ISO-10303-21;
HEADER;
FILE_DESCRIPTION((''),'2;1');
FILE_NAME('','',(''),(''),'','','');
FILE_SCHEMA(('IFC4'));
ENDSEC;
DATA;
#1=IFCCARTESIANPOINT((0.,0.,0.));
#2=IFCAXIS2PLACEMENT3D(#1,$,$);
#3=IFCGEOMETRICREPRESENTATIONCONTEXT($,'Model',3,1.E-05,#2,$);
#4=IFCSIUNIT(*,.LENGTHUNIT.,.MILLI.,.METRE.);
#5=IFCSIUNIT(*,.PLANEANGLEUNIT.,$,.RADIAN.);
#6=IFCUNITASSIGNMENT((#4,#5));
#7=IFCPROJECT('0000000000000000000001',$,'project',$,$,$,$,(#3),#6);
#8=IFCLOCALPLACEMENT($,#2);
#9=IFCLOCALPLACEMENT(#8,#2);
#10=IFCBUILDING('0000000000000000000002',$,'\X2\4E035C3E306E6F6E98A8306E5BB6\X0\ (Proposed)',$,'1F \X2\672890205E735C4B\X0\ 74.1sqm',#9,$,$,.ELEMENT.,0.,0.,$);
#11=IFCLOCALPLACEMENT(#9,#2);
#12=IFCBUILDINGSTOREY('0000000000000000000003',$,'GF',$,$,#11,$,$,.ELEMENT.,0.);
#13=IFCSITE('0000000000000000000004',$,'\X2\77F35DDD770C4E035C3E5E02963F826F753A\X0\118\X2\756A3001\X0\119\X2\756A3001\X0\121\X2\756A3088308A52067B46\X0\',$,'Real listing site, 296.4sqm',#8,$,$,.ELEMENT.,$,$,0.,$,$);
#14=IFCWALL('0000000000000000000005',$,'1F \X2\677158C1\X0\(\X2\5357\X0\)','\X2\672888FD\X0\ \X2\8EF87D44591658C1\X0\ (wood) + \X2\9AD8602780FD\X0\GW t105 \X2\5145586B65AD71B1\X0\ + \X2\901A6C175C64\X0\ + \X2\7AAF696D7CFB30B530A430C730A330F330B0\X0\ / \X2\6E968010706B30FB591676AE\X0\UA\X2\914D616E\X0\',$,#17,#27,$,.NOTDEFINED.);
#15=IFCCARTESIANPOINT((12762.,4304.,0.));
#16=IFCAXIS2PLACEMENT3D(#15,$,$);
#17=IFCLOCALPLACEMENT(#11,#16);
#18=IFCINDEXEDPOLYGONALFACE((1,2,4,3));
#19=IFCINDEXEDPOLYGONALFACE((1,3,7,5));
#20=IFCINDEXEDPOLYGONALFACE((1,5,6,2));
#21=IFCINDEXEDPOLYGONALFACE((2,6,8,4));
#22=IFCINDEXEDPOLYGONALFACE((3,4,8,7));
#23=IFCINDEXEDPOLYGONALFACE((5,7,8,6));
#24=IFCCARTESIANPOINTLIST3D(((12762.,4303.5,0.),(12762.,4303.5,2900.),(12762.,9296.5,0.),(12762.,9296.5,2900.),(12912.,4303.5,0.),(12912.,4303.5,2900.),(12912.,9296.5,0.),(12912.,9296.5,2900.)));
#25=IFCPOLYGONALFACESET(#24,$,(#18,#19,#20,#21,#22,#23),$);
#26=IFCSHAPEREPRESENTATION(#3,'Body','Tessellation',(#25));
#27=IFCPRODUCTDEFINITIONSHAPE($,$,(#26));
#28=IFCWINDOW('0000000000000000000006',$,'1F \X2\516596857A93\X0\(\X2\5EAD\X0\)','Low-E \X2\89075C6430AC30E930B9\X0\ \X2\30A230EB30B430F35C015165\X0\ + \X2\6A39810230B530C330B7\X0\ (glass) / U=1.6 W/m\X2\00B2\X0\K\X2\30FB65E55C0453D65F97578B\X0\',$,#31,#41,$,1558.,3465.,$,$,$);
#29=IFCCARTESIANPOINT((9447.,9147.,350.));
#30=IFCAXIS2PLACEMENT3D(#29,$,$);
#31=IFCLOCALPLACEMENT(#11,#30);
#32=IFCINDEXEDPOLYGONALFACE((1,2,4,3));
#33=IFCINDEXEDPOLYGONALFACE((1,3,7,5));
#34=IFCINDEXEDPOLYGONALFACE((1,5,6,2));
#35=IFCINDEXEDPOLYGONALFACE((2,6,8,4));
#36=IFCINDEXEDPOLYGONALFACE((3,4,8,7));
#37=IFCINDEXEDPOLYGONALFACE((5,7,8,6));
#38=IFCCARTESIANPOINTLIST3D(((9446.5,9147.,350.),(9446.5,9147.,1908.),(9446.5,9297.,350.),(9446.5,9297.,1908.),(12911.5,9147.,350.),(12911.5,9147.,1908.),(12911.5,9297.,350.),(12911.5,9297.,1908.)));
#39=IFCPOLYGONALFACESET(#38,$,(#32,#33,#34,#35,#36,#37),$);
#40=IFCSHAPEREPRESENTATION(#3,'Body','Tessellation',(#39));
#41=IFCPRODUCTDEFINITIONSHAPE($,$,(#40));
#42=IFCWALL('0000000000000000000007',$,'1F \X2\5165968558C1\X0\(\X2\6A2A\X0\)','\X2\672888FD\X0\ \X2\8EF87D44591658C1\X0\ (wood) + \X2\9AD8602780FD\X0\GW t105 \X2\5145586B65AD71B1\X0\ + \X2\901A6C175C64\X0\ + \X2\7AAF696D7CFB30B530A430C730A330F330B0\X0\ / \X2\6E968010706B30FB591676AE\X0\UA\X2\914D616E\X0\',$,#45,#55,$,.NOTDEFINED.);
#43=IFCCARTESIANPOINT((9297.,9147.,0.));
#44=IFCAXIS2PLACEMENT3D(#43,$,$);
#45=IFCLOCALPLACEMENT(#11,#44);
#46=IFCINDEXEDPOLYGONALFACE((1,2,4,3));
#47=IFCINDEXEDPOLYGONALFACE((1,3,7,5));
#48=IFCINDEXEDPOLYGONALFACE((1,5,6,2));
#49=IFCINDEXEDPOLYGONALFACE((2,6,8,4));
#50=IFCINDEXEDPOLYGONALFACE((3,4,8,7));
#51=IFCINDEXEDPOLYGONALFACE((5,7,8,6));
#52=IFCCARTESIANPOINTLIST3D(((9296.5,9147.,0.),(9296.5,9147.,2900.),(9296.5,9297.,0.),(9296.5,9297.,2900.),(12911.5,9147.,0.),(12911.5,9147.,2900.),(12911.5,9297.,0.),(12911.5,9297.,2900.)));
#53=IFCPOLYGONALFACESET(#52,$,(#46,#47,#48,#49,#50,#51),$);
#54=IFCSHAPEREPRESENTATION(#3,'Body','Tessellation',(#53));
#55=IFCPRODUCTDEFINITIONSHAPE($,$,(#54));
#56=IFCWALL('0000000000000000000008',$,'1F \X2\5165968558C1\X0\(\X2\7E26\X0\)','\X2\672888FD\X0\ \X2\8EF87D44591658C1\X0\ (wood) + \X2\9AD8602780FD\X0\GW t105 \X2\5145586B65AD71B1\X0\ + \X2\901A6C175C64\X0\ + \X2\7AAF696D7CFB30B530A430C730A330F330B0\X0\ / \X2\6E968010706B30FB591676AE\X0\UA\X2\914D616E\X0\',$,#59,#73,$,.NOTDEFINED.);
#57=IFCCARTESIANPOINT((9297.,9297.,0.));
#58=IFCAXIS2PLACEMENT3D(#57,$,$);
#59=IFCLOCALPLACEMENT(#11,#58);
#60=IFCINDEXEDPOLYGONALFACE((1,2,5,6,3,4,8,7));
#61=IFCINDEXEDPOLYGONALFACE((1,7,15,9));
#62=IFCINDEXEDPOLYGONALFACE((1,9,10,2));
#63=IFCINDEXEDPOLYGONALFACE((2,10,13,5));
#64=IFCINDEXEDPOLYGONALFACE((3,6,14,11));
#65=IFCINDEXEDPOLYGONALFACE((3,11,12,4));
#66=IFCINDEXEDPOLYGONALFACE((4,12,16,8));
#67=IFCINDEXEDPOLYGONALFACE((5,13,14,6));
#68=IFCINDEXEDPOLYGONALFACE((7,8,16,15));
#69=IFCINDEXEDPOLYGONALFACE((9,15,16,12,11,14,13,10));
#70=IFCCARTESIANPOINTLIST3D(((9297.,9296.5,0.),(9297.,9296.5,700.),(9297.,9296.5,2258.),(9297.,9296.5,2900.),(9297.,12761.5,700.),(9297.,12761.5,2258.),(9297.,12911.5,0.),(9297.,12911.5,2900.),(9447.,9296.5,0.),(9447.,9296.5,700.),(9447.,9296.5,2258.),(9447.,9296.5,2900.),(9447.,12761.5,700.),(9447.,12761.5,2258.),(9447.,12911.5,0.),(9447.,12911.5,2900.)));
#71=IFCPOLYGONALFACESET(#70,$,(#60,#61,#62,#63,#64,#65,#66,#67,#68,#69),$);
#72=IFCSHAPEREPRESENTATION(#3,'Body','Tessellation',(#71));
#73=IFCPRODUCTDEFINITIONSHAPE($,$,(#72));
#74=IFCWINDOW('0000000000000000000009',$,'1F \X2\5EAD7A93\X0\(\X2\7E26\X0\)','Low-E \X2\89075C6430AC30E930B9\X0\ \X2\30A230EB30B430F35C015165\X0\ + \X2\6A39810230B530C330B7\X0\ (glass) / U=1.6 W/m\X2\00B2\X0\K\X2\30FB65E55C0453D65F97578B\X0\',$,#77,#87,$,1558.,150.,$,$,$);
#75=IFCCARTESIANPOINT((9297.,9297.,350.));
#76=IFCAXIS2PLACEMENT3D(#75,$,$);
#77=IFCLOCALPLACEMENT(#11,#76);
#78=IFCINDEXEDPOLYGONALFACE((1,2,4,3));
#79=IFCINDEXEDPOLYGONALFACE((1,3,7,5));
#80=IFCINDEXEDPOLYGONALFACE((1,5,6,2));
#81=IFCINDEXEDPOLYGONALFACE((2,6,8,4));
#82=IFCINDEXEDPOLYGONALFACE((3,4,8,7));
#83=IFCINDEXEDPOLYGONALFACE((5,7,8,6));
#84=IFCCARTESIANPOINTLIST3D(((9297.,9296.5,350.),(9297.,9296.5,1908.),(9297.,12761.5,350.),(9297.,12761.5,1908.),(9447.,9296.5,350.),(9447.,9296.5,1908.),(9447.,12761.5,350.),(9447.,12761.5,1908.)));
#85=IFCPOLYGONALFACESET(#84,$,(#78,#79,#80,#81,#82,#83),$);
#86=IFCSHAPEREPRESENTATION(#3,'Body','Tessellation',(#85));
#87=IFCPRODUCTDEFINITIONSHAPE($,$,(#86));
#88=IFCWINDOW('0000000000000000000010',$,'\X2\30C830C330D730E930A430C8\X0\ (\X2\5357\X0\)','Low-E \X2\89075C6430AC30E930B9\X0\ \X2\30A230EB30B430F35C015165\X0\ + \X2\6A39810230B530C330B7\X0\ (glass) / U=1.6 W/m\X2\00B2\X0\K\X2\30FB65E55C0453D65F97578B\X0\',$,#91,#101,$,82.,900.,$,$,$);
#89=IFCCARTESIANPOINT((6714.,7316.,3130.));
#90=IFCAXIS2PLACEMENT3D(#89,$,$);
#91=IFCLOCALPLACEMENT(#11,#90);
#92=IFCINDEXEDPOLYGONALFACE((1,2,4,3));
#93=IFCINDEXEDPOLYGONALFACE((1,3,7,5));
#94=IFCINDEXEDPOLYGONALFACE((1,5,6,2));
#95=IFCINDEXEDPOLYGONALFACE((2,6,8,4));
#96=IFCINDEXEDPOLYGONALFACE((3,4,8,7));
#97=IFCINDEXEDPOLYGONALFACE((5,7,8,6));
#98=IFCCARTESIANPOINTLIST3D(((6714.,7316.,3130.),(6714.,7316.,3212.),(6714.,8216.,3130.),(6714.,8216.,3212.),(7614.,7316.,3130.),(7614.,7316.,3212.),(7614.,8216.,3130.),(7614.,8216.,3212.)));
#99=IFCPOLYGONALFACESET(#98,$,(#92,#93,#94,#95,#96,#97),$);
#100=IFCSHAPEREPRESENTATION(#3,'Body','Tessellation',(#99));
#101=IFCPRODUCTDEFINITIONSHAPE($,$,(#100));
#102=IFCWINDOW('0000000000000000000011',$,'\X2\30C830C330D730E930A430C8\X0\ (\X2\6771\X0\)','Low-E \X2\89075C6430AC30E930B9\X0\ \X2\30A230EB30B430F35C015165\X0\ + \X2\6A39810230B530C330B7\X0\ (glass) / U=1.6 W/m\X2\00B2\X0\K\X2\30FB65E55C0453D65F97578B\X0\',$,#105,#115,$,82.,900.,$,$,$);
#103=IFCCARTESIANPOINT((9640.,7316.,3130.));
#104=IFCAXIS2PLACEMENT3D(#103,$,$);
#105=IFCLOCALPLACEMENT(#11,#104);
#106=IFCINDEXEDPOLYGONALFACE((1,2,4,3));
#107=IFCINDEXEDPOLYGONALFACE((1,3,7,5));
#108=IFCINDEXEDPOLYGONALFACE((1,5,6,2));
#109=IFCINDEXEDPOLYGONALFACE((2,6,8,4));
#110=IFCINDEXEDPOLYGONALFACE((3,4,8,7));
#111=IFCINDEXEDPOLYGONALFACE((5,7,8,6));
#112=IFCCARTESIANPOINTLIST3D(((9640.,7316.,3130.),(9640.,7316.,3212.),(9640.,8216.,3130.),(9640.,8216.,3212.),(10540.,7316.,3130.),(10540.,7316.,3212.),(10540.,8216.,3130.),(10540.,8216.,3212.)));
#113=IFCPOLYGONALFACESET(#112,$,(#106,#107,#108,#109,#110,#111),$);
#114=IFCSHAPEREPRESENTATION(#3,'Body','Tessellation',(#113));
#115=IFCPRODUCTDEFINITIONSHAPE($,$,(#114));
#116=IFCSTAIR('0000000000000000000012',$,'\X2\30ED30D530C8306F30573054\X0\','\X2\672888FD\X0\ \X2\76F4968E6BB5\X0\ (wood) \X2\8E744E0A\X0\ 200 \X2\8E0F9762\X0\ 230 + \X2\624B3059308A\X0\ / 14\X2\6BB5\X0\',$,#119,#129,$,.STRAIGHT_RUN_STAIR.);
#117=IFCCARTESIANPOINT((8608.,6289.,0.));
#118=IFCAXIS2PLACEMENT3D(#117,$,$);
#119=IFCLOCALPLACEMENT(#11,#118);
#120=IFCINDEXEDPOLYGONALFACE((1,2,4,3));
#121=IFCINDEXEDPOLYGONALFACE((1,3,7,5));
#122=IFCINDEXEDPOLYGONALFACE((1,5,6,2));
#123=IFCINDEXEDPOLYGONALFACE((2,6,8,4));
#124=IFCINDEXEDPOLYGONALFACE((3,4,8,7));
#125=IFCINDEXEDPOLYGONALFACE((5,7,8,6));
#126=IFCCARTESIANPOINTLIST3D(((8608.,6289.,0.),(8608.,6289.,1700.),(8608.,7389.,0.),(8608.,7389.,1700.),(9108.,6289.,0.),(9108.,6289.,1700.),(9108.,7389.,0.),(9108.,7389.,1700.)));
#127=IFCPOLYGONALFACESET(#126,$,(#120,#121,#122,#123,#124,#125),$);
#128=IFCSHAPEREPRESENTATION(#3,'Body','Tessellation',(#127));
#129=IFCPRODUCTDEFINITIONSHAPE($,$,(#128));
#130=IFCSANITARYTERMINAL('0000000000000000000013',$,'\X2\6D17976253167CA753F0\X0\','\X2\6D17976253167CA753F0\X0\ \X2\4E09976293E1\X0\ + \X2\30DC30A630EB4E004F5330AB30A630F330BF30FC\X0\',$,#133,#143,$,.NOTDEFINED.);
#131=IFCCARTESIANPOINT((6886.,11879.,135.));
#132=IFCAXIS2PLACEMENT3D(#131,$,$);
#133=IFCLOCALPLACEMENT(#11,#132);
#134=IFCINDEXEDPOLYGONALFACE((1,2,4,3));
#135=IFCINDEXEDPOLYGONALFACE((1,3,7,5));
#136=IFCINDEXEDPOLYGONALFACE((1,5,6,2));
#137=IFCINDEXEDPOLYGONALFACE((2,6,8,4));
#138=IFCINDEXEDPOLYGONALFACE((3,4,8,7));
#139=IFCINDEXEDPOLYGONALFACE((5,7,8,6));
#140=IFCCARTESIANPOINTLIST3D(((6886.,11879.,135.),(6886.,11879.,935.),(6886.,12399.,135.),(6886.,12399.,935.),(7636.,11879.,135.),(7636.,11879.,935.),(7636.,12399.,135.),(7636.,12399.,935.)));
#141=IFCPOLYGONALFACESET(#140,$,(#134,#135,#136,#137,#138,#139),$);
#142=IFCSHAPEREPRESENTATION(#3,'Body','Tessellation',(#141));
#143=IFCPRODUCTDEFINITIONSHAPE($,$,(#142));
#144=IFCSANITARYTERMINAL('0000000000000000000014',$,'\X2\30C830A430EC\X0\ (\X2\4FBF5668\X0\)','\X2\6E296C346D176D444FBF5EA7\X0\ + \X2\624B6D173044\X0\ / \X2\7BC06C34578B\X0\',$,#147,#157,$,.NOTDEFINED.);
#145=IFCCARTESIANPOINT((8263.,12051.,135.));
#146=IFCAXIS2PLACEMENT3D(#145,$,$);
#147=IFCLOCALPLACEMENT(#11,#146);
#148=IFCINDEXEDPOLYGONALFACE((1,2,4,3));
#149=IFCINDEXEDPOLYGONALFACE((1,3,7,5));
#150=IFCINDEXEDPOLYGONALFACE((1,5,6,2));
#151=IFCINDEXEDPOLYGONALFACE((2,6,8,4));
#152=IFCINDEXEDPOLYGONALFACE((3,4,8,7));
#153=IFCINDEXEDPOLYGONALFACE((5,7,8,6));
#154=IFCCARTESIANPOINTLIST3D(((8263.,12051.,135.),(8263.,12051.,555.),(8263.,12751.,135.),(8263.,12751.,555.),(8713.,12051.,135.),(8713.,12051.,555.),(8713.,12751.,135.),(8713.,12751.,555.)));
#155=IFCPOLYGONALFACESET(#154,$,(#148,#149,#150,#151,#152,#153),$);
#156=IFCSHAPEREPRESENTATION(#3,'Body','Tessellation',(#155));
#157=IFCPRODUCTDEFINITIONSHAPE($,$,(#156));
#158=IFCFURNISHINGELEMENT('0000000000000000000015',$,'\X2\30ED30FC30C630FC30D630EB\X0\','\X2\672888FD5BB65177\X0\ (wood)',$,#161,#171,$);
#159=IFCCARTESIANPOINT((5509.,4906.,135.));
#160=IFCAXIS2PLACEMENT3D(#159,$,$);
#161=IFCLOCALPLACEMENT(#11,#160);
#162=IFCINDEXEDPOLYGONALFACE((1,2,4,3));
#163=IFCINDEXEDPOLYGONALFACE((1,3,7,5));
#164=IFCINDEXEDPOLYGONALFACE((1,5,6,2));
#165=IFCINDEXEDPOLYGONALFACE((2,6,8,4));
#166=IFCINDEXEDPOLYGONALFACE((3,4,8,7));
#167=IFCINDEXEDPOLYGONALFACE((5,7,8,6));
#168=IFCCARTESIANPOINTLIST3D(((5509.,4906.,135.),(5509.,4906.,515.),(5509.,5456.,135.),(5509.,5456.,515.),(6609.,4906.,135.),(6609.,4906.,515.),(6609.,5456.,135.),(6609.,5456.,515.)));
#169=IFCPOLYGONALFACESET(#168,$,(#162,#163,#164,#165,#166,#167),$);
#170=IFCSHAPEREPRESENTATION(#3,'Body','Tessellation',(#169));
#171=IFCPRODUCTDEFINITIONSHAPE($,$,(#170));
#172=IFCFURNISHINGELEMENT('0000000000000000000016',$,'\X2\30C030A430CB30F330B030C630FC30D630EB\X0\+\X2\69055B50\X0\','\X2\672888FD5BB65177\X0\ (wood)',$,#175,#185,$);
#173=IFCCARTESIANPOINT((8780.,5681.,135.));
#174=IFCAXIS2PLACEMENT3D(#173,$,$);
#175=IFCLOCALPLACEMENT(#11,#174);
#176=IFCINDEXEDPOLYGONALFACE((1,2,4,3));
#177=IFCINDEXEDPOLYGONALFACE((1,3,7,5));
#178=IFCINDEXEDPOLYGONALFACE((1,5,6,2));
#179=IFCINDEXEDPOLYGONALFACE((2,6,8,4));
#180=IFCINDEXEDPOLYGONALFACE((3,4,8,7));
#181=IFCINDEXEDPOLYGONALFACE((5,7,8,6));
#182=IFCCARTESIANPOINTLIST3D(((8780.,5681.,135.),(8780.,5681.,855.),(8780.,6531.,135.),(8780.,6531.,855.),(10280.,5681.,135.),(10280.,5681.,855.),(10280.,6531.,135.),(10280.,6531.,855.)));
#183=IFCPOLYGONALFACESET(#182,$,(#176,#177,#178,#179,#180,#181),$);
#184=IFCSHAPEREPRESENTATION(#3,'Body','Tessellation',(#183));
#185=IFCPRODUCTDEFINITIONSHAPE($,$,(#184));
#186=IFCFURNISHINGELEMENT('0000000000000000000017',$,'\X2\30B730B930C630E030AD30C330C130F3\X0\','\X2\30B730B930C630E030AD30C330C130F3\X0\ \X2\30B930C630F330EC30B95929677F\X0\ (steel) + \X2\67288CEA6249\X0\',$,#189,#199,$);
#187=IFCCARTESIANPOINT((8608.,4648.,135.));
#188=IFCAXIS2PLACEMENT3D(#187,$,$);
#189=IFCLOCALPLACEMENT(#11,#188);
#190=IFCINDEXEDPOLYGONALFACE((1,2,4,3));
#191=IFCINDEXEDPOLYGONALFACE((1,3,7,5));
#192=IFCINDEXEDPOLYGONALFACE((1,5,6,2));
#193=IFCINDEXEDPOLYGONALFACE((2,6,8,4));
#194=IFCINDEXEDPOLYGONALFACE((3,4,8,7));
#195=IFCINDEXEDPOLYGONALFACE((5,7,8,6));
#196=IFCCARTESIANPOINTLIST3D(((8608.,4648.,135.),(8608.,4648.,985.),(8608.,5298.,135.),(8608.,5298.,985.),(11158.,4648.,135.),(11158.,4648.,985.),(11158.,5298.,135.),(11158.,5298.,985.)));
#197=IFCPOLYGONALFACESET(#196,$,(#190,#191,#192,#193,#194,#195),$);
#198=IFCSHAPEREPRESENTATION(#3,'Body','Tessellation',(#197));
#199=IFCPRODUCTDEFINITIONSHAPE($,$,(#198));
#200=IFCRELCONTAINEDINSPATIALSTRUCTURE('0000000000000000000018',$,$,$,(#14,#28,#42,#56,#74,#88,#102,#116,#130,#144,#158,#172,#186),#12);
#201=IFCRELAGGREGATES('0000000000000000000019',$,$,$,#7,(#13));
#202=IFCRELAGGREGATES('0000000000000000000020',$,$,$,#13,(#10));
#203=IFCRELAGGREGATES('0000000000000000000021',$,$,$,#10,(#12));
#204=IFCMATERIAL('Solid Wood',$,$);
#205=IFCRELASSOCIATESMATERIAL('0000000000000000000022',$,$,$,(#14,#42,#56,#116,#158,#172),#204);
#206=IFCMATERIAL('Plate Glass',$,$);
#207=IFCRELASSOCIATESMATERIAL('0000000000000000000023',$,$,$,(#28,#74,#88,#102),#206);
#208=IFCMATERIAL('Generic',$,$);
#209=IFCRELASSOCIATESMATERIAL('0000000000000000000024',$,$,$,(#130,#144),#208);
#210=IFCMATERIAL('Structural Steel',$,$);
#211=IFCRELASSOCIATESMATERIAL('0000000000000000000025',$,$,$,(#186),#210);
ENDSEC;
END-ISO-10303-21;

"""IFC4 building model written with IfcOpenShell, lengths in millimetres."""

from ifc_helpers import new_model, si_unit, frame, frame_2d, origin, place, context, project, spatial, rectangle, extrude, material, element, fill, save


model = new_model("IFC4")

# Units and contexts
model_context = context("Model", 3, precision=1e-05, world=origin())
ifc_project = project(units=[si_unit("LENGTHUNIT", "METRE", prefix="MILLI"), si_unit("PLANEANGLEUNIT", "RADIAN")], contexts=[model_context])

# Site, building, storey
site_placement = place(None, origin())
site = spatial("IfcSite", under=ifc_project, at=site_placement, Name="石川県七尾市阿良町118番、119番、121番より分筆", ObjectType="Real listing site, 296.4sqm", CompositionType="ELEMENT", RefElevation=0.0)
building_placement = place(site_placement, origin())
building = spatial("IfcBuilding", under=site, at=building_placement, Name="七尾の潮風の家 (Proposed)", ObjectType="1F 木造平屋 74.1sqm", CompositionType="ELEMENT", ElevationOfRefHeight=0.0, ElevationOfTerrain=0.0)
storey_placement = place(building_placement, origin())
storey = spatial("IfcBuildingStorey", under=building, at=storey_placement, Name="GF", CompositionType="ELEMENT", Elevation=0.0)

# Shared definitions
ifc_material_1 = material(Name="Solid Wood")

# Wall, opening, window
wall_1_placement = place(storey_placement, frame((12762.0, 4304.0, 0.0)))
wall_1 = element("IfcWall", 1, at=wall_1_placement, inside=storey, material=ifc_material_1, Name="1F 東壁(南)", Description="木製 軸組外壁 (wood) + 高性能GW t105 充填断熱 + 通気層 + 窯業系サイディング / 準耐火・外皮UA配慮", PredefinedType="NOTDEFINED", context=model_context, shape_type="SweptSolid", body=[
    extrude(rectangle(XDim=150.0, YDim=4993.0, at=frame_2d((75.0, 2496.0))), frame((12762.0, 4304.0, 0.0)), (0.0, 0.0, 1.0), 2900.0),
])
opening_1_placement = place(storey_placement, frame((9447.0, 9147.0, 350.0)))
opening_1 = element("IfcOpeningElement", 2, at=opening_1_placement, cuts=wall_1, PredefinedType="NOTDEFINED", context=model_context, shape_type="SweptSolid", body=[
    extrude(rectangle(XDim=3465.0, YDim=150.0, at=frame_2d((1732.0, 75.0))), frame((9447.0, 9147.0, 350.0)), (0.0, 0.0, 1.0), 1558.0),
])
ifc_material_2 = material(Name="Plate Glass")
window_1_placement = place(storey_placement, frame((9447.0, 9147.0, 350.0)))
window_1 = element("IfcWindow", 3, at=window_1_placement, inside=storey, material=ifc_material_2, Name="1F 入隅窓(庭)", Description="Low-E 複層ガラス アルゴン封入 + 樹脂サッシ (glass) / U=1.6 W/m²K・日射取得型", OverallHeight=1558.0, OverallWidth=3465.0, context=model_context, shape_type="SweptSolid", body=[
    extrude(rectangle(XDim=3465.0, YDim=150.0, at=frame_2d((1732.0, 75.0))), frame((9447.0, 9147.0, 350.0)), (0.0, 0.0, 1.0), 1558.0),
])
fill(opening_1, window_1)

# Wall
wall_2_placement = place(storey_placement, frame((9297.0, 9147.0, 0.0)))
element("IfcWall", 4, at=wall_2_placement, inside=storey, material=ifc_material_1, Name="1F 入隅壁(横)", Description="木製 軸組外壁 (wood) + 高性能GW t105 充填断熱 + 通気層 + 窯業系サイディング / 準耐火・外皮UA配慮", PredefinedType="NOTDEFINED", context=model_context, shape_type="SweptSolid", body=[
    extrude(rectangle(XDim=3615.0, YDim=150.0, at=frame_2d((1807.0, 75.0))), frame((9297.0, 9147.0, 0.0)), (0.0, 0.0, 1.0), 2900.0),
])

# Wall, opening, window
wall_3_placement = place(storey_placement, frame((9297.0, 9297.0, 0.0)))
wall_3 = element("IfcWall", 5, at=wall_3_placement, inside=storey, material=ifc_material_1, Name="1F 入隅壁(縦)", Description="木製 軸組外壁 (wood) + 高性能GW t105 充填断熱 + 通気層 + 窯業系サイディング / 準耐火・外皮UA配慮", PredefinedType="NOTDEFINED", context=model_context, shape_type="SweptSolid", body=[
    extrude(rectangle(XDim=150.0, YDim=3615.0, at=frame_2d((75.0, 1807.0))), frame((9297.0, 9297.0, 0.0)), (0.0, 0.0, 1.0), 2900.0),
])
opening_2_placement = place(storey_placement, frame((9297.0, 9297.0, 350.0)))
opening_2 = element("IfcOpeningElement", 6, at=opening_2_placement, cuts=wall_3, PredefinedType="NOTDEFINED", context=model_context, shape_type="SweptSolid", body=[
    extrude(rectangle(XDim=150.0, YDim=3465.0, at=frame_2d((75.0, 1732.0))), frame((9297.0, 9297.0, 350.0)), (0.0, 0.0, 1.0), 1558.0),
])
window_2_placement = place(storey_placement, frame((9297.0, 9297.0, 350.0)))
window_2 = element("IfcWindow", 7, at=window_2_placement, inside=storey, material=ifc_material_2, Name="1F 庭窓(縦)", Description="Low-E 複層ガラス アルゴン封入 + 樹脂サッシ (glass) / U=1.6 W/m²K・日射取得型", OverallHeight=1558.0, OverallWidth=150.0, context=model_context, shape_type="SweptSolid", body=[
    extrude(rectangle(XDim=150.0, YDim=3465.0, at=frame_2d((75.0, 1732.0))), frame((9297.0, 9297.0, 350.0)), (0.0, 0.0, 1.0), 1558.0),
])
fill(opening_2, window_2)

# Windows
window_3_placement = place(storey_placement, frame((6714.0, 7316.0, 3130.0)))
element("IfcWindow", 8, at=window_3_placement, inside=storey, material=ifc_material_2, Name="トップライト (南)", Description="Low-E 複層ガラス アルゴン封入 + 樹脂サッシ (glass) / U=1.6 W/m²K・日射取得型", OverallHeight=82.0, OverallWidth=900.0, context=model_context, shape_type="SweptSolid", body=[
    extrude(rectangle(XDim=900.0, YDim=900.0, at=frame_2d((450.0, 450.0))), frame((6714.0, 7316.0, 3130.0)), (0.0, 0.0, 1.0), 82.0),
])
window_4_placement = place(storey_placement, frame((9640.0, 7316.0, 3130.0)))
element("IfcWindow", 9, at=window_4_placement, inside=storey, material=ifc_material_2, Name="トップライト (東)", Description="Low-E 複層ガラス アルゴン封入 + 樹脂サッシ (glass) / U=1.6 W/m²K・日射取得型", OverallHeight=82.0, OverallWidth=900.0, context=model_context, shape_type="SweptSolid", body=[
    extrude(rectangle(XDim=900.0, YDim=900.0, at=frame_2d((450.0, 450.0))), frame((9640.0, 7316.0, 3130.0)), (0.0, 0.0, 1.0), 82.0),
])

# Stair
stair_placement = place(storey_placement, frame((8608.0, 6289.0, 0.0)))
element("IfcStair", 10, at=stair_placement, inside=storey, material=ifc_material_1, Name="ロフトはしご", Description="木製 直階段 (wood) 蹴上 200 踏面 230 + 手すり / 14段", PredefinedType="STRAIGHT_RUN_STAIR", context=model_context, shape_type="SweptSolid", body=[
    extrude(rectangle(XDim=500.0, YDim=1100.0, at=frame_2d((250.0, 550.0))), frame((8608.0, 6289.0, 0.0)), (0.0, 0.0, 1.0), 1700.0),
])

# Sanitary terminals
ifc_material_3 = material(Name="Generic")
sanitary_terminal_1_placement = place(storey_placement, frame((6886.0, 11879.0, 135.0)))
element("IfcSanitaryTerminal", 11, at=sanitary_terminal_1_placement, inside=storey, material=ifc_material_3, Name="洗面化粧台", Description="洗面化粧台 三面鏡 + ボウル一体カウンター", PredefinedType="NOTDEFINED", context=model_context, shape_type="SweptSolid", body=[
    extrude(rectangle(XDim=750.0, YDim=520.0, at=frame_2d((375.0, 260.0))), frame((6886.0, 11879.0, 135.0)), (0.0, 0.0, 1.0), 800.0),
])
sanitary_terminal_2_placement = place(storey_placement, frame((8263.0, 12051.0, 135.0)))
element("IfcSanitaryTerminal", 12, at=sanitary_terminal_2_placement, inside=storey, material=ifc_material_3, Name="トイレ (便器)", Description="温水洗浄便座 + 手洗い / 節水型", PredefinedType="NOTDEFINED", context=model_context, shape_type="SweptSolid", body=[
    extrude(rectangle(XDim=450.0, YDim=700.0, at=frame_2d((225.0, 350.0))), frame((8263.0, 12051.0, 135.0)), (0.0, 0.0, 1.0), 420.0),
])

# Furnishing elements
furnishing_1_placement = place(storey_placement, frame((5509.0, 4906.0, 135.0)))
element("IfcFurnishingElement", 13, at=furnishing_1_placement, inside=storey, material=ifc_material_1, Name="ローテーブル", Description="木製家具 (wood)", context=model_context, shape_type="SweptSolid", body=[
    extrude(rectangle(XDim=1100.0, YDim=550.0, at=frame_2d((550.0, 275.0))), frame((5509.0, 4906.0, 135.0)), (0.0, 0.0, 1.0), 380.0),
])
furnishing_2_placement = place(storey_placement, frame((8780.0, 5681.0, 135.0)))
element("IfcFurnishingElement", 14, at=furnishing_2_placement, inside=storey, material=ifc_material_1, Name="ダイニングテーブル+椅子", Description="木製家具 (wood)", context=model_context, shape_type="SweptSolid", body=[
    extrude(rectangle(XDim=1500.0, YDim=850.0, at=frame_2d((750.0, 425.0))), frame((8780.0, 5681.0, 135.0)), (0.0, 0.0, 1.0), 720.0),
])
ifc_material_4 = material(Name="Structural Steel")
furnishing_3_placement = place(storey_placement, frame((8608.0, 4648.0, 135.0)))
element("IfcFurnishingElement", 15, at=furnishing_3_placement, inside=storey, material=ifc_material_4, Name="システムキッチン", Description="システムキッチン ステンレス天板 (steel) + 木質扉", context=model_context, shape_type="SweptSolid", body=[
    extrude(rectangle(XDim=2550.0, YDim=650.0, at=frame_2d((1275.0, 325.0))), frame((8608.0, 4648.0, 135.0)), (0.0, 0.0, 1.0), 850.0),
])

save(model, "model.ifc")
